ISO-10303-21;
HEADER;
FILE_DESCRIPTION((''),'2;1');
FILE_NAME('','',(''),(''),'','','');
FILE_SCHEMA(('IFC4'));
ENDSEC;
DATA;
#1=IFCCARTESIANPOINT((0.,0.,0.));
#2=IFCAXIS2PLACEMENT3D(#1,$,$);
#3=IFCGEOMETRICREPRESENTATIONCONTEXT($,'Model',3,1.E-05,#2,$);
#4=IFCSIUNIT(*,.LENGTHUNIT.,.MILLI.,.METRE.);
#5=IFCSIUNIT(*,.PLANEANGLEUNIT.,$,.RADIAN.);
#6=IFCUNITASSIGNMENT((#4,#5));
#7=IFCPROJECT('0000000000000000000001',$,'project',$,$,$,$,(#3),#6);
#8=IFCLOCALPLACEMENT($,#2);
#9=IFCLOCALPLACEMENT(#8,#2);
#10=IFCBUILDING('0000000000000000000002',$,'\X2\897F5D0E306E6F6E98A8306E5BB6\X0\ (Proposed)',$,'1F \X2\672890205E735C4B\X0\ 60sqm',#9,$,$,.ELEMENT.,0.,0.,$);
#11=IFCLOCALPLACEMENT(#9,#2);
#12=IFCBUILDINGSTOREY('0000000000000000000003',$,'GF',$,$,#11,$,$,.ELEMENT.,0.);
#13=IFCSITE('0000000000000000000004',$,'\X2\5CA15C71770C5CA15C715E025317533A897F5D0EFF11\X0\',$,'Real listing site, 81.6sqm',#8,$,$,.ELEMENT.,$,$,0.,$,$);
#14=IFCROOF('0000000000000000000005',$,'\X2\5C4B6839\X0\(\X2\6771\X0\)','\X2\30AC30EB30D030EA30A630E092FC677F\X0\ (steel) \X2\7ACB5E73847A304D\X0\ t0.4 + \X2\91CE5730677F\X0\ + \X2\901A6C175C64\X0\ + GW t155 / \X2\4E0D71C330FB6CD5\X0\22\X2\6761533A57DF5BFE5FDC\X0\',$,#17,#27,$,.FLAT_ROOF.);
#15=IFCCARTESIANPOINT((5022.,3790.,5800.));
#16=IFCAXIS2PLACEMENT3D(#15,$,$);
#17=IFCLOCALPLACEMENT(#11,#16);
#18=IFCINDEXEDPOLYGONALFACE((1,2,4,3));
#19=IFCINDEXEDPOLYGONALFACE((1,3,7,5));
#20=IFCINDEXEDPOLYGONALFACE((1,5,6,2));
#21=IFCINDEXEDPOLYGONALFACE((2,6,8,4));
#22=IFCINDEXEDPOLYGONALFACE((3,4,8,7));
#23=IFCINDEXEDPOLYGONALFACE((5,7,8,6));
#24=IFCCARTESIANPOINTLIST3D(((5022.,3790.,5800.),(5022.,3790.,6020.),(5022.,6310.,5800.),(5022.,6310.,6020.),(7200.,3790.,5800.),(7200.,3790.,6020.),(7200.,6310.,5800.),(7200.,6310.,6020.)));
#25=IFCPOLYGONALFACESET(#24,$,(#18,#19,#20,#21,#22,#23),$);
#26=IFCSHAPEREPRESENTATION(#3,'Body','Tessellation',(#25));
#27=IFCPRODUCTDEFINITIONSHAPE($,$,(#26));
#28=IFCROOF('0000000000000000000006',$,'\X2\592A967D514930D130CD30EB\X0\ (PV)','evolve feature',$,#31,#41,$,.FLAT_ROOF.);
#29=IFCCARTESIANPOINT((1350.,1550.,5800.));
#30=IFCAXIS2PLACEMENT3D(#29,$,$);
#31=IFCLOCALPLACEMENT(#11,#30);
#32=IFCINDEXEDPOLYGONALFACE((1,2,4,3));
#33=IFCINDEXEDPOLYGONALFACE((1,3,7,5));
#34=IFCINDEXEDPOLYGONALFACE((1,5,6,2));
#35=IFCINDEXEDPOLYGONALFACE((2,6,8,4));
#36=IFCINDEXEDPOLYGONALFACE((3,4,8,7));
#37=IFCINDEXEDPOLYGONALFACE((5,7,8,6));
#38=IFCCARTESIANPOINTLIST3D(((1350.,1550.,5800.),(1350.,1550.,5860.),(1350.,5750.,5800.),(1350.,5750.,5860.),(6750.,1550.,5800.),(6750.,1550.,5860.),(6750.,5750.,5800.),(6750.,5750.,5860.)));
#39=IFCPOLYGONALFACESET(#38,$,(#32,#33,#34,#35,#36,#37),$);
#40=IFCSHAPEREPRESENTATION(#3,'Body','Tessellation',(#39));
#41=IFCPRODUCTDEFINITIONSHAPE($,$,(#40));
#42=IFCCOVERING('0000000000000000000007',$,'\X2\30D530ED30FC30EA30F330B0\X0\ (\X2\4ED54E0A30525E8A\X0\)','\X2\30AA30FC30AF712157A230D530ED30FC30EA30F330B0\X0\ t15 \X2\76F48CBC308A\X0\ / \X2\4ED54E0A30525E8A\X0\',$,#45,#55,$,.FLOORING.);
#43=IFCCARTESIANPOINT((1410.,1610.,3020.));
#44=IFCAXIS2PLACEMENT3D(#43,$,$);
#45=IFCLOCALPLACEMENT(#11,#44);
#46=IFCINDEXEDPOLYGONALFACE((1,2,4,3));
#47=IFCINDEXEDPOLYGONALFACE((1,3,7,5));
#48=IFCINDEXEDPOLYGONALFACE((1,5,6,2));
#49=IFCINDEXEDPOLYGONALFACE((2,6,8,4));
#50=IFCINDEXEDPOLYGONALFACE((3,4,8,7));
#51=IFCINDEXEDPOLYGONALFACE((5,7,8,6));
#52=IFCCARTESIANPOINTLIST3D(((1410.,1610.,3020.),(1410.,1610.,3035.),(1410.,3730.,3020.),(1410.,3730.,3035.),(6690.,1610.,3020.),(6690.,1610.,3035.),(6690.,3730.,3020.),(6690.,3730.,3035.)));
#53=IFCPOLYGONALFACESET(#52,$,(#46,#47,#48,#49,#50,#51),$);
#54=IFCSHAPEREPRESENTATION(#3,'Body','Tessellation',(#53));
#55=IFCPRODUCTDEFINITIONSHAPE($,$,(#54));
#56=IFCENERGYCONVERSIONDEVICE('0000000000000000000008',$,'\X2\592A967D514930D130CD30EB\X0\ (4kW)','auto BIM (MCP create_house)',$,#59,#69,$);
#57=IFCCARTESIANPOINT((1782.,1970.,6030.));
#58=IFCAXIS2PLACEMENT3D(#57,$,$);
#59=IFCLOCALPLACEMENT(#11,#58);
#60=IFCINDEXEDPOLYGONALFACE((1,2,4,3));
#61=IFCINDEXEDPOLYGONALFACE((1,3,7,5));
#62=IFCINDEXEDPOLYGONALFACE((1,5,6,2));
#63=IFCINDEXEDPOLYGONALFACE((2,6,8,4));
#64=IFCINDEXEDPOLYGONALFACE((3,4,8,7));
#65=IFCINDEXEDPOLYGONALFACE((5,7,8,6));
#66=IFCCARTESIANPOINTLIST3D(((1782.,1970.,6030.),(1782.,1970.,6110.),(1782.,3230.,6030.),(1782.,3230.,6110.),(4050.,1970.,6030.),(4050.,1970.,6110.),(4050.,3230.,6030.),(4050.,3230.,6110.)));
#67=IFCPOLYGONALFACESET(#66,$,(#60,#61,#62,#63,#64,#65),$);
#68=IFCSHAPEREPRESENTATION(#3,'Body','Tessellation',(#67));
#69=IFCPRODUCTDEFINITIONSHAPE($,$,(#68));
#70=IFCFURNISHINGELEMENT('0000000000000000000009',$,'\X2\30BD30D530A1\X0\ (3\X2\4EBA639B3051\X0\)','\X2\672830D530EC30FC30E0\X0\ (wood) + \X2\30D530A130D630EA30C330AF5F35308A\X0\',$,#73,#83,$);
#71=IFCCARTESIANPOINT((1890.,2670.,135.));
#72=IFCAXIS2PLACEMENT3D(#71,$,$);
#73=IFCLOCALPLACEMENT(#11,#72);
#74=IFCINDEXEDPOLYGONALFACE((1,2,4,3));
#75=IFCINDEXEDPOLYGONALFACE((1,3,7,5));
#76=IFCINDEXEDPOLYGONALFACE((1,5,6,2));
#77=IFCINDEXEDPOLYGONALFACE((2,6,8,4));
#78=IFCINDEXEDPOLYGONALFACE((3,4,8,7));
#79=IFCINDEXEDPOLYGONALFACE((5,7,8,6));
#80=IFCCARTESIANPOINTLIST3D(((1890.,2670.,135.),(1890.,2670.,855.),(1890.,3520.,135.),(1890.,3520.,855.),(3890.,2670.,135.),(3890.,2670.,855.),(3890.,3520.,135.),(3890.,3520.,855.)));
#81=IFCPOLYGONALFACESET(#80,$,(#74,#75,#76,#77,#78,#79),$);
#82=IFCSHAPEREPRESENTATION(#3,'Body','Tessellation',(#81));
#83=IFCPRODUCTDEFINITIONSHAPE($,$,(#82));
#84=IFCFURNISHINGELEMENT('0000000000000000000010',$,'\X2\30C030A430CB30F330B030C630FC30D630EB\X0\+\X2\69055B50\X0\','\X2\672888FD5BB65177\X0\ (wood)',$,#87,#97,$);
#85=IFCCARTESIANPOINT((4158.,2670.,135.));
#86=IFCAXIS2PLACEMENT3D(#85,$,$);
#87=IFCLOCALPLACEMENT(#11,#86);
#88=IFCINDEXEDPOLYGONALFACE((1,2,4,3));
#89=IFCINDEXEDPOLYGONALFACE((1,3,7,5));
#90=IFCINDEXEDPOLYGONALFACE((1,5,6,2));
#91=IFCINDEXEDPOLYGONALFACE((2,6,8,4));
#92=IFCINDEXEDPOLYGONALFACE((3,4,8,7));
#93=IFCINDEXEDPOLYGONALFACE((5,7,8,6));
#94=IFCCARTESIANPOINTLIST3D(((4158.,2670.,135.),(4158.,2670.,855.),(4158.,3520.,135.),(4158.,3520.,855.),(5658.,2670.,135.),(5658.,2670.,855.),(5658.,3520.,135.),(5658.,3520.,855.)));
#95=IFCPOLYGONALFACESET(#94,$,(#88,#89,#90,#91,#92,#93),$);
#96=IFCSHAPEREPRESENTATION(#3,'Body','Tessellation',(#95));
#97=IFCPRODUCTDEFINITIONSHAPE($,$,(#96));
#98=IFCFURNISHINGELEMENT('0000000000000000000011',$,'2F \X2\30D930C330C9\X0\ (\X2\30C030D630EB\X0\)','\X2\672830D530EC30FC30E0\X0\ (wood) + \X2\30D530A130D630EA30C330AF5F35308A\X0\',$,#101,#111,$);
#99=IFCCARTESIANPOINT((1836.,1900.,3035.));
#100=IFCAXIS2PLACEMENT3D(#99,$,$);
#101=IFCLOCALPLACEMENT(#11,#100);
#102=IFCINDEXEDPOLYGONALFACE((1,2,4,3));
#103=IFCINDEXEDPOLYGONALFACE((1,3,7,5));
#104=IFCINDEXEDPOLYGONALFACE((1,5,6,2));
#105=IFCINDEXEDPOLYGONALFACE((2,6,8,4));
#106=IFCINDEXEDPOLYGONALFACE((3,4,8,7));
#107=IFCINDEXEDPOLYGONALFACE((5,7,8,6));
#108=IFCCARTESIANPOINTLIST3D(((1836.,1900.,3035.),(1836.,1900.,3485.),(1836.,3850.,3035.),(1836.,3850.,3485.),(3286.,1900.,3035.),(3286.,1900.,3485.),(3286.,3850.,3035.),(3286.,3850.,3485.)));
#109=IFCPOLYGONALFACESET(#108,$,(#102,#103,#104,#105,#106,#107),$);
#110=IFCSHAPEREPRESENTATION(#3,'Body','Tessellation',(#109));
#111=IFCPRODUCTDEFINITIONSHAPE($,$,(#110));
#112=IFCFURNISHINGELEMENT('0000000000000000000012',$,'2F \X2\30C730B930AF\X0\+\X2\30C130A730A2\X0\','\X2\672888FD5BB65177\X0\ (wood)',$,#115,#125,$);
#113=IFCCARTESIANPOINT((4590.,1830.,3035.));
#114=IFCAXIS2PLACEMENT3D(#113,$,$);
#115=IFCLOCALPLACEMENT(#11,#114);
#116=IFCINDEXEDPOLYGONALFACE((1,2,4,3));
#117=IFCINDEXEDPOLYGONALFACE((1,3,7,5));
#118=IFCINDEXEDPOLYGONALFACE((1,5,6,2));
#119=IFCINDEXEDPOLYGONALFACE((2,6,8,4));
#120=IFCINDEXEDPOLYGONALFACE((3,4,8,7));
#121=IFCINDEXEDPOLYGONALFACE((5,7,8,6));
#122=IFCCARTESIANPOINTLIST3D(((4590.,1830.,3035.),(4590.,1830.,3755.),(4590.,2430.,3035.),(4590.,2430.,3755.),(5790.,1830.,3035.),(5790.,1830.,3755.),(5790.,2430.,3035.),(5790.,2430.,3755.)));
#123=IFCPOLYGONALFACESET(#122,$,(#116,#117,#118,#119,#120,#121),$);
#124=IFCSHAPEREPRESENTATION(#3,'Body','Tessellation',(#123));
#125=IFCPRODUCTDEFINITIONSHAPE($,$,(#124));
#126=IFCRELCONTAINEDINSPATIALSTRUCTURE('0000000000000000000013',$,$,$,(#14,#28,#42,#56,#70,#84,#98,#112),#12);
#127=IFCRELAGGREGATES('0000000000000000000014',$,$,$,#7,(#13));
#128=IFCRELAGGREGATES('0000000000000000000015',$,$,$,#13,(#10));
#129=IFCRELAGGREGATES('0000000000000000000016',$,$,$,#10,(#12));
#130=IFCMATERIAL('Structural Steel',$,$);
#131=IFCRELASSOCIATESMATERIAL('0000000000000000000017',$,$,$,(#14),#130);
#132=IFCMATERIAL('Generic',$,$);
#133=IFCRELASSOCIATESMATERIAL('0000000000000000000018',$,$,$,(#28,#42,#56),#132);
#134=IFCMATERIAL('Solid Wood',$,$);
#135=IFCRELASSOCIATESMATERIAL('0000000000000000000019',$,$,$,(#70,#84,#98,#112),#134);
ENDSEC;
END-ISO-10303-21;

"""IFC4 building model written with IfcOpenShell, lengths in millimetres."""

from ifc_helpers import new_model, si_unit, frame, frame_2d, origin, place, context, project, spatial, rectangle, extrude, material, element, save


model = new_model("IFC4")

# Units and contexts
model_context = context("Model", 3, precision=1e-05, world=origin())
ifc_project = project(units=[si_unit("LENGTHUNIT", "METRE", prefix="MILLI"), si_unit("PLANEANGLEUNIT", "RADIAN")], contexts=[model_context])

# Site, building, storey
site_placement = place(None, origin())
site = spatial("IfcSite", under=ifc_project, at=site_placement, Name="岡山県岡山市北区西崎１", ObjectType="Real listing site, 81.6sqm", CompositionType="ELEMENT", RefElevation=0.0)
building_placement = place(site_placement, origin())
building = spatial("IfcBuilding", under=site, at=building_placement, Name="西崎の潮風の家 (Proposed)", ObjectType="1F 木造平屋 60sqm", CompositionType="ELEMENT", ElevationOfRefHeight=0.0, ElevationOfTerrain=0.0)
storey_placement = place(building_placement, origin())
storey = spatial("IfcBuildingStorey", under=building, at=storey_placement, Name="GF", CompositionType="ELEMENT", Elevation=0.0)

# Shared definitions
ifc_material_1 = material(Name="Solid Wood")

# Roofs
ifc_material_2 = material(Name="Structural Steel")
roof_1_placement = place(storey_placement, frame((5022.0, 3790.0, 5800.0)))
element("IfcRoof", 1, at=roof_1_placement, inside=storey, material=ifc_material_2, Name="屋根(東)", Description="ガルバリウム鋼板 (steel) 立平葺き t0.4 + 野地板 + 通気層 + GW t155 / 不燃・法22条区域対応", PredefinedType="FLAT_ROOF", context=model_context, shape_type="SweptSolid", body=[
    extrude(rectangle(XDim=2178.0, YDim=2520.0, at=frame_2d((1089.0, 1260.0))), frame((5022.0, 3790.0, 5800.0)), (0.0, 0.0, 1.0), 220.0),
])
ifc_material_3 = material(Name="Generic")
roof_2_placement = place(storey_placement, frame((1350.0, 1550.0, 5800.0)))
element("IfcRoof", 2, at=roof_2_placement, inside=storey, material=ifc_material_3, Name="太陽光パネル (PV)", Description="evolve feature", PredefinedType="FLAT_ROOF", context=model_context, shape_type="SweptSolid", body=[
    extrude(rectangle(XDim=5400.0, YDim=4200.0, at=frame_2d((2700.0, 2100.0))), frame((1350.0, 1550.0, 5800.0)), (0.0, 0.0, 1.0), 60.0),
])

# Covering
covering_placement = place(storey_placement, frame((1410.0, 1610.0, 3020.0)))
element("IfcCovering", 3, at=covering_placement, inside=storey, material=ifc_material_3, Name="フローリング (仕上げ床)", Description="オーク無垢フローリング t15 直貼り / 仕上げ床", PredefinedType="FLOORING", context=model_context, shape_type="SweptSolid", body=[
    extrude(rectangle(XDim=5280.0, YDim=2120.0, at=frame_2d((2640.0, 1060.0))), frame((1410.0, 1610.0, 3020.0)), (0.0, 0.0, 1.0), 15.0),
])

# Energy conversion device
energy_conversion_device_placement = place(storey_placement, frame((1782.0, 1970.0, 6030.0)))
element("IfcEnergyConversionDevice", 4, at=energy_conversion_device_placement, inside=storey, material=ifc_material_3, Name="太陽光パネル (4kW)", Description="auto BIM (MCP create_house)", context=model_context, shape_type="SweptSolid", body=[
    extrude(rectangle(XDim=2268.0, YDim=1260.0, at=frame_2d((1134.0, 630.0))), frame((1782.0, 1970.0, 6030.0)), (0.0, 0.0, 1.0), 80.0),
])

# Furnishing elements
furnishing_1_placement = place(storey_placement, frame((1890.0, 2670.0, 135.0)))
element("IfcFurnishingElement", 5, at=furnishing_1_placement, inside=storey, material=ifc_material_1, Name="ソファ (3人掛け)", Description="木フレーム (wood) + ファブリック張り", context=model_context, shape_type="SweptSolid", body=[
    extrude(rectangle(XDim=2000.0, YDim=850.0, at=frame_2d((1000.0, 425.0))), frame((1890.0, 2670.0, 135.0)), (0.0, 0.0, 1.0), 720.0),
])
furnishing_2_placement = place(storey_placement, frame((4158.0, 2670.0, 135.0)))
element("IfcFurnishingElement", 6, at=furnishing_2_placement, inside=storey, material=ifc_material_1, Name="ダイニングテーブル+椅子", Description="木製家具 (wood)", context=model_context, shape_type="SweptSolid", body=[
    extrude(rectangle(XDim=1500.0, YDim=850.0, at=frame_2d((750.0, 425.0))), frame((4158.0, 2670.0, 135.0)), (0.0, 0.0, 1.0), 720.0),
])
furnishing_3_placement = place(storey_placement, frame((1836.0, 1900.0, 3035.0)))
element("IfcFurnishingElement", 7, at=furnishing_3_placement, inside=storey, material=ifc_material_1, Name="2F ベッド (ダブル)", Description="木フレーム (wood) + ファブリック張り", context=model_context, shape_type="SweptSolid", body=[
    extrude(rectangle(XDim=1450.0, YDim=1950.0, at=frame_2d((725.0, 975.0))), frame((1836.0, 1900.0, 3035.0)), (0.0, 0.0, 1.0), 450.0),
])
furnishing_4_placement = place(storey_placement, frame((4590.0, 1830.0, 3035.0)))
element("IfcFurnishingElement", 8, at=furnishing_4_placement, inside=storey, material=ifc_material_1, Name="2F デスク+チェア", Description="木製家具 (wood)", context=model_context, shape_type="SweptSolid", body=[
    extrude(rectangle(XDim=1200.0, YDim=600.0, at=frame_2d((600.0, 300.0))), frame((4590.0, 1830.0, 3035.0)), (0.0, 0.0, 1.0), 720.0),
])

save(model, "model.ifc")
